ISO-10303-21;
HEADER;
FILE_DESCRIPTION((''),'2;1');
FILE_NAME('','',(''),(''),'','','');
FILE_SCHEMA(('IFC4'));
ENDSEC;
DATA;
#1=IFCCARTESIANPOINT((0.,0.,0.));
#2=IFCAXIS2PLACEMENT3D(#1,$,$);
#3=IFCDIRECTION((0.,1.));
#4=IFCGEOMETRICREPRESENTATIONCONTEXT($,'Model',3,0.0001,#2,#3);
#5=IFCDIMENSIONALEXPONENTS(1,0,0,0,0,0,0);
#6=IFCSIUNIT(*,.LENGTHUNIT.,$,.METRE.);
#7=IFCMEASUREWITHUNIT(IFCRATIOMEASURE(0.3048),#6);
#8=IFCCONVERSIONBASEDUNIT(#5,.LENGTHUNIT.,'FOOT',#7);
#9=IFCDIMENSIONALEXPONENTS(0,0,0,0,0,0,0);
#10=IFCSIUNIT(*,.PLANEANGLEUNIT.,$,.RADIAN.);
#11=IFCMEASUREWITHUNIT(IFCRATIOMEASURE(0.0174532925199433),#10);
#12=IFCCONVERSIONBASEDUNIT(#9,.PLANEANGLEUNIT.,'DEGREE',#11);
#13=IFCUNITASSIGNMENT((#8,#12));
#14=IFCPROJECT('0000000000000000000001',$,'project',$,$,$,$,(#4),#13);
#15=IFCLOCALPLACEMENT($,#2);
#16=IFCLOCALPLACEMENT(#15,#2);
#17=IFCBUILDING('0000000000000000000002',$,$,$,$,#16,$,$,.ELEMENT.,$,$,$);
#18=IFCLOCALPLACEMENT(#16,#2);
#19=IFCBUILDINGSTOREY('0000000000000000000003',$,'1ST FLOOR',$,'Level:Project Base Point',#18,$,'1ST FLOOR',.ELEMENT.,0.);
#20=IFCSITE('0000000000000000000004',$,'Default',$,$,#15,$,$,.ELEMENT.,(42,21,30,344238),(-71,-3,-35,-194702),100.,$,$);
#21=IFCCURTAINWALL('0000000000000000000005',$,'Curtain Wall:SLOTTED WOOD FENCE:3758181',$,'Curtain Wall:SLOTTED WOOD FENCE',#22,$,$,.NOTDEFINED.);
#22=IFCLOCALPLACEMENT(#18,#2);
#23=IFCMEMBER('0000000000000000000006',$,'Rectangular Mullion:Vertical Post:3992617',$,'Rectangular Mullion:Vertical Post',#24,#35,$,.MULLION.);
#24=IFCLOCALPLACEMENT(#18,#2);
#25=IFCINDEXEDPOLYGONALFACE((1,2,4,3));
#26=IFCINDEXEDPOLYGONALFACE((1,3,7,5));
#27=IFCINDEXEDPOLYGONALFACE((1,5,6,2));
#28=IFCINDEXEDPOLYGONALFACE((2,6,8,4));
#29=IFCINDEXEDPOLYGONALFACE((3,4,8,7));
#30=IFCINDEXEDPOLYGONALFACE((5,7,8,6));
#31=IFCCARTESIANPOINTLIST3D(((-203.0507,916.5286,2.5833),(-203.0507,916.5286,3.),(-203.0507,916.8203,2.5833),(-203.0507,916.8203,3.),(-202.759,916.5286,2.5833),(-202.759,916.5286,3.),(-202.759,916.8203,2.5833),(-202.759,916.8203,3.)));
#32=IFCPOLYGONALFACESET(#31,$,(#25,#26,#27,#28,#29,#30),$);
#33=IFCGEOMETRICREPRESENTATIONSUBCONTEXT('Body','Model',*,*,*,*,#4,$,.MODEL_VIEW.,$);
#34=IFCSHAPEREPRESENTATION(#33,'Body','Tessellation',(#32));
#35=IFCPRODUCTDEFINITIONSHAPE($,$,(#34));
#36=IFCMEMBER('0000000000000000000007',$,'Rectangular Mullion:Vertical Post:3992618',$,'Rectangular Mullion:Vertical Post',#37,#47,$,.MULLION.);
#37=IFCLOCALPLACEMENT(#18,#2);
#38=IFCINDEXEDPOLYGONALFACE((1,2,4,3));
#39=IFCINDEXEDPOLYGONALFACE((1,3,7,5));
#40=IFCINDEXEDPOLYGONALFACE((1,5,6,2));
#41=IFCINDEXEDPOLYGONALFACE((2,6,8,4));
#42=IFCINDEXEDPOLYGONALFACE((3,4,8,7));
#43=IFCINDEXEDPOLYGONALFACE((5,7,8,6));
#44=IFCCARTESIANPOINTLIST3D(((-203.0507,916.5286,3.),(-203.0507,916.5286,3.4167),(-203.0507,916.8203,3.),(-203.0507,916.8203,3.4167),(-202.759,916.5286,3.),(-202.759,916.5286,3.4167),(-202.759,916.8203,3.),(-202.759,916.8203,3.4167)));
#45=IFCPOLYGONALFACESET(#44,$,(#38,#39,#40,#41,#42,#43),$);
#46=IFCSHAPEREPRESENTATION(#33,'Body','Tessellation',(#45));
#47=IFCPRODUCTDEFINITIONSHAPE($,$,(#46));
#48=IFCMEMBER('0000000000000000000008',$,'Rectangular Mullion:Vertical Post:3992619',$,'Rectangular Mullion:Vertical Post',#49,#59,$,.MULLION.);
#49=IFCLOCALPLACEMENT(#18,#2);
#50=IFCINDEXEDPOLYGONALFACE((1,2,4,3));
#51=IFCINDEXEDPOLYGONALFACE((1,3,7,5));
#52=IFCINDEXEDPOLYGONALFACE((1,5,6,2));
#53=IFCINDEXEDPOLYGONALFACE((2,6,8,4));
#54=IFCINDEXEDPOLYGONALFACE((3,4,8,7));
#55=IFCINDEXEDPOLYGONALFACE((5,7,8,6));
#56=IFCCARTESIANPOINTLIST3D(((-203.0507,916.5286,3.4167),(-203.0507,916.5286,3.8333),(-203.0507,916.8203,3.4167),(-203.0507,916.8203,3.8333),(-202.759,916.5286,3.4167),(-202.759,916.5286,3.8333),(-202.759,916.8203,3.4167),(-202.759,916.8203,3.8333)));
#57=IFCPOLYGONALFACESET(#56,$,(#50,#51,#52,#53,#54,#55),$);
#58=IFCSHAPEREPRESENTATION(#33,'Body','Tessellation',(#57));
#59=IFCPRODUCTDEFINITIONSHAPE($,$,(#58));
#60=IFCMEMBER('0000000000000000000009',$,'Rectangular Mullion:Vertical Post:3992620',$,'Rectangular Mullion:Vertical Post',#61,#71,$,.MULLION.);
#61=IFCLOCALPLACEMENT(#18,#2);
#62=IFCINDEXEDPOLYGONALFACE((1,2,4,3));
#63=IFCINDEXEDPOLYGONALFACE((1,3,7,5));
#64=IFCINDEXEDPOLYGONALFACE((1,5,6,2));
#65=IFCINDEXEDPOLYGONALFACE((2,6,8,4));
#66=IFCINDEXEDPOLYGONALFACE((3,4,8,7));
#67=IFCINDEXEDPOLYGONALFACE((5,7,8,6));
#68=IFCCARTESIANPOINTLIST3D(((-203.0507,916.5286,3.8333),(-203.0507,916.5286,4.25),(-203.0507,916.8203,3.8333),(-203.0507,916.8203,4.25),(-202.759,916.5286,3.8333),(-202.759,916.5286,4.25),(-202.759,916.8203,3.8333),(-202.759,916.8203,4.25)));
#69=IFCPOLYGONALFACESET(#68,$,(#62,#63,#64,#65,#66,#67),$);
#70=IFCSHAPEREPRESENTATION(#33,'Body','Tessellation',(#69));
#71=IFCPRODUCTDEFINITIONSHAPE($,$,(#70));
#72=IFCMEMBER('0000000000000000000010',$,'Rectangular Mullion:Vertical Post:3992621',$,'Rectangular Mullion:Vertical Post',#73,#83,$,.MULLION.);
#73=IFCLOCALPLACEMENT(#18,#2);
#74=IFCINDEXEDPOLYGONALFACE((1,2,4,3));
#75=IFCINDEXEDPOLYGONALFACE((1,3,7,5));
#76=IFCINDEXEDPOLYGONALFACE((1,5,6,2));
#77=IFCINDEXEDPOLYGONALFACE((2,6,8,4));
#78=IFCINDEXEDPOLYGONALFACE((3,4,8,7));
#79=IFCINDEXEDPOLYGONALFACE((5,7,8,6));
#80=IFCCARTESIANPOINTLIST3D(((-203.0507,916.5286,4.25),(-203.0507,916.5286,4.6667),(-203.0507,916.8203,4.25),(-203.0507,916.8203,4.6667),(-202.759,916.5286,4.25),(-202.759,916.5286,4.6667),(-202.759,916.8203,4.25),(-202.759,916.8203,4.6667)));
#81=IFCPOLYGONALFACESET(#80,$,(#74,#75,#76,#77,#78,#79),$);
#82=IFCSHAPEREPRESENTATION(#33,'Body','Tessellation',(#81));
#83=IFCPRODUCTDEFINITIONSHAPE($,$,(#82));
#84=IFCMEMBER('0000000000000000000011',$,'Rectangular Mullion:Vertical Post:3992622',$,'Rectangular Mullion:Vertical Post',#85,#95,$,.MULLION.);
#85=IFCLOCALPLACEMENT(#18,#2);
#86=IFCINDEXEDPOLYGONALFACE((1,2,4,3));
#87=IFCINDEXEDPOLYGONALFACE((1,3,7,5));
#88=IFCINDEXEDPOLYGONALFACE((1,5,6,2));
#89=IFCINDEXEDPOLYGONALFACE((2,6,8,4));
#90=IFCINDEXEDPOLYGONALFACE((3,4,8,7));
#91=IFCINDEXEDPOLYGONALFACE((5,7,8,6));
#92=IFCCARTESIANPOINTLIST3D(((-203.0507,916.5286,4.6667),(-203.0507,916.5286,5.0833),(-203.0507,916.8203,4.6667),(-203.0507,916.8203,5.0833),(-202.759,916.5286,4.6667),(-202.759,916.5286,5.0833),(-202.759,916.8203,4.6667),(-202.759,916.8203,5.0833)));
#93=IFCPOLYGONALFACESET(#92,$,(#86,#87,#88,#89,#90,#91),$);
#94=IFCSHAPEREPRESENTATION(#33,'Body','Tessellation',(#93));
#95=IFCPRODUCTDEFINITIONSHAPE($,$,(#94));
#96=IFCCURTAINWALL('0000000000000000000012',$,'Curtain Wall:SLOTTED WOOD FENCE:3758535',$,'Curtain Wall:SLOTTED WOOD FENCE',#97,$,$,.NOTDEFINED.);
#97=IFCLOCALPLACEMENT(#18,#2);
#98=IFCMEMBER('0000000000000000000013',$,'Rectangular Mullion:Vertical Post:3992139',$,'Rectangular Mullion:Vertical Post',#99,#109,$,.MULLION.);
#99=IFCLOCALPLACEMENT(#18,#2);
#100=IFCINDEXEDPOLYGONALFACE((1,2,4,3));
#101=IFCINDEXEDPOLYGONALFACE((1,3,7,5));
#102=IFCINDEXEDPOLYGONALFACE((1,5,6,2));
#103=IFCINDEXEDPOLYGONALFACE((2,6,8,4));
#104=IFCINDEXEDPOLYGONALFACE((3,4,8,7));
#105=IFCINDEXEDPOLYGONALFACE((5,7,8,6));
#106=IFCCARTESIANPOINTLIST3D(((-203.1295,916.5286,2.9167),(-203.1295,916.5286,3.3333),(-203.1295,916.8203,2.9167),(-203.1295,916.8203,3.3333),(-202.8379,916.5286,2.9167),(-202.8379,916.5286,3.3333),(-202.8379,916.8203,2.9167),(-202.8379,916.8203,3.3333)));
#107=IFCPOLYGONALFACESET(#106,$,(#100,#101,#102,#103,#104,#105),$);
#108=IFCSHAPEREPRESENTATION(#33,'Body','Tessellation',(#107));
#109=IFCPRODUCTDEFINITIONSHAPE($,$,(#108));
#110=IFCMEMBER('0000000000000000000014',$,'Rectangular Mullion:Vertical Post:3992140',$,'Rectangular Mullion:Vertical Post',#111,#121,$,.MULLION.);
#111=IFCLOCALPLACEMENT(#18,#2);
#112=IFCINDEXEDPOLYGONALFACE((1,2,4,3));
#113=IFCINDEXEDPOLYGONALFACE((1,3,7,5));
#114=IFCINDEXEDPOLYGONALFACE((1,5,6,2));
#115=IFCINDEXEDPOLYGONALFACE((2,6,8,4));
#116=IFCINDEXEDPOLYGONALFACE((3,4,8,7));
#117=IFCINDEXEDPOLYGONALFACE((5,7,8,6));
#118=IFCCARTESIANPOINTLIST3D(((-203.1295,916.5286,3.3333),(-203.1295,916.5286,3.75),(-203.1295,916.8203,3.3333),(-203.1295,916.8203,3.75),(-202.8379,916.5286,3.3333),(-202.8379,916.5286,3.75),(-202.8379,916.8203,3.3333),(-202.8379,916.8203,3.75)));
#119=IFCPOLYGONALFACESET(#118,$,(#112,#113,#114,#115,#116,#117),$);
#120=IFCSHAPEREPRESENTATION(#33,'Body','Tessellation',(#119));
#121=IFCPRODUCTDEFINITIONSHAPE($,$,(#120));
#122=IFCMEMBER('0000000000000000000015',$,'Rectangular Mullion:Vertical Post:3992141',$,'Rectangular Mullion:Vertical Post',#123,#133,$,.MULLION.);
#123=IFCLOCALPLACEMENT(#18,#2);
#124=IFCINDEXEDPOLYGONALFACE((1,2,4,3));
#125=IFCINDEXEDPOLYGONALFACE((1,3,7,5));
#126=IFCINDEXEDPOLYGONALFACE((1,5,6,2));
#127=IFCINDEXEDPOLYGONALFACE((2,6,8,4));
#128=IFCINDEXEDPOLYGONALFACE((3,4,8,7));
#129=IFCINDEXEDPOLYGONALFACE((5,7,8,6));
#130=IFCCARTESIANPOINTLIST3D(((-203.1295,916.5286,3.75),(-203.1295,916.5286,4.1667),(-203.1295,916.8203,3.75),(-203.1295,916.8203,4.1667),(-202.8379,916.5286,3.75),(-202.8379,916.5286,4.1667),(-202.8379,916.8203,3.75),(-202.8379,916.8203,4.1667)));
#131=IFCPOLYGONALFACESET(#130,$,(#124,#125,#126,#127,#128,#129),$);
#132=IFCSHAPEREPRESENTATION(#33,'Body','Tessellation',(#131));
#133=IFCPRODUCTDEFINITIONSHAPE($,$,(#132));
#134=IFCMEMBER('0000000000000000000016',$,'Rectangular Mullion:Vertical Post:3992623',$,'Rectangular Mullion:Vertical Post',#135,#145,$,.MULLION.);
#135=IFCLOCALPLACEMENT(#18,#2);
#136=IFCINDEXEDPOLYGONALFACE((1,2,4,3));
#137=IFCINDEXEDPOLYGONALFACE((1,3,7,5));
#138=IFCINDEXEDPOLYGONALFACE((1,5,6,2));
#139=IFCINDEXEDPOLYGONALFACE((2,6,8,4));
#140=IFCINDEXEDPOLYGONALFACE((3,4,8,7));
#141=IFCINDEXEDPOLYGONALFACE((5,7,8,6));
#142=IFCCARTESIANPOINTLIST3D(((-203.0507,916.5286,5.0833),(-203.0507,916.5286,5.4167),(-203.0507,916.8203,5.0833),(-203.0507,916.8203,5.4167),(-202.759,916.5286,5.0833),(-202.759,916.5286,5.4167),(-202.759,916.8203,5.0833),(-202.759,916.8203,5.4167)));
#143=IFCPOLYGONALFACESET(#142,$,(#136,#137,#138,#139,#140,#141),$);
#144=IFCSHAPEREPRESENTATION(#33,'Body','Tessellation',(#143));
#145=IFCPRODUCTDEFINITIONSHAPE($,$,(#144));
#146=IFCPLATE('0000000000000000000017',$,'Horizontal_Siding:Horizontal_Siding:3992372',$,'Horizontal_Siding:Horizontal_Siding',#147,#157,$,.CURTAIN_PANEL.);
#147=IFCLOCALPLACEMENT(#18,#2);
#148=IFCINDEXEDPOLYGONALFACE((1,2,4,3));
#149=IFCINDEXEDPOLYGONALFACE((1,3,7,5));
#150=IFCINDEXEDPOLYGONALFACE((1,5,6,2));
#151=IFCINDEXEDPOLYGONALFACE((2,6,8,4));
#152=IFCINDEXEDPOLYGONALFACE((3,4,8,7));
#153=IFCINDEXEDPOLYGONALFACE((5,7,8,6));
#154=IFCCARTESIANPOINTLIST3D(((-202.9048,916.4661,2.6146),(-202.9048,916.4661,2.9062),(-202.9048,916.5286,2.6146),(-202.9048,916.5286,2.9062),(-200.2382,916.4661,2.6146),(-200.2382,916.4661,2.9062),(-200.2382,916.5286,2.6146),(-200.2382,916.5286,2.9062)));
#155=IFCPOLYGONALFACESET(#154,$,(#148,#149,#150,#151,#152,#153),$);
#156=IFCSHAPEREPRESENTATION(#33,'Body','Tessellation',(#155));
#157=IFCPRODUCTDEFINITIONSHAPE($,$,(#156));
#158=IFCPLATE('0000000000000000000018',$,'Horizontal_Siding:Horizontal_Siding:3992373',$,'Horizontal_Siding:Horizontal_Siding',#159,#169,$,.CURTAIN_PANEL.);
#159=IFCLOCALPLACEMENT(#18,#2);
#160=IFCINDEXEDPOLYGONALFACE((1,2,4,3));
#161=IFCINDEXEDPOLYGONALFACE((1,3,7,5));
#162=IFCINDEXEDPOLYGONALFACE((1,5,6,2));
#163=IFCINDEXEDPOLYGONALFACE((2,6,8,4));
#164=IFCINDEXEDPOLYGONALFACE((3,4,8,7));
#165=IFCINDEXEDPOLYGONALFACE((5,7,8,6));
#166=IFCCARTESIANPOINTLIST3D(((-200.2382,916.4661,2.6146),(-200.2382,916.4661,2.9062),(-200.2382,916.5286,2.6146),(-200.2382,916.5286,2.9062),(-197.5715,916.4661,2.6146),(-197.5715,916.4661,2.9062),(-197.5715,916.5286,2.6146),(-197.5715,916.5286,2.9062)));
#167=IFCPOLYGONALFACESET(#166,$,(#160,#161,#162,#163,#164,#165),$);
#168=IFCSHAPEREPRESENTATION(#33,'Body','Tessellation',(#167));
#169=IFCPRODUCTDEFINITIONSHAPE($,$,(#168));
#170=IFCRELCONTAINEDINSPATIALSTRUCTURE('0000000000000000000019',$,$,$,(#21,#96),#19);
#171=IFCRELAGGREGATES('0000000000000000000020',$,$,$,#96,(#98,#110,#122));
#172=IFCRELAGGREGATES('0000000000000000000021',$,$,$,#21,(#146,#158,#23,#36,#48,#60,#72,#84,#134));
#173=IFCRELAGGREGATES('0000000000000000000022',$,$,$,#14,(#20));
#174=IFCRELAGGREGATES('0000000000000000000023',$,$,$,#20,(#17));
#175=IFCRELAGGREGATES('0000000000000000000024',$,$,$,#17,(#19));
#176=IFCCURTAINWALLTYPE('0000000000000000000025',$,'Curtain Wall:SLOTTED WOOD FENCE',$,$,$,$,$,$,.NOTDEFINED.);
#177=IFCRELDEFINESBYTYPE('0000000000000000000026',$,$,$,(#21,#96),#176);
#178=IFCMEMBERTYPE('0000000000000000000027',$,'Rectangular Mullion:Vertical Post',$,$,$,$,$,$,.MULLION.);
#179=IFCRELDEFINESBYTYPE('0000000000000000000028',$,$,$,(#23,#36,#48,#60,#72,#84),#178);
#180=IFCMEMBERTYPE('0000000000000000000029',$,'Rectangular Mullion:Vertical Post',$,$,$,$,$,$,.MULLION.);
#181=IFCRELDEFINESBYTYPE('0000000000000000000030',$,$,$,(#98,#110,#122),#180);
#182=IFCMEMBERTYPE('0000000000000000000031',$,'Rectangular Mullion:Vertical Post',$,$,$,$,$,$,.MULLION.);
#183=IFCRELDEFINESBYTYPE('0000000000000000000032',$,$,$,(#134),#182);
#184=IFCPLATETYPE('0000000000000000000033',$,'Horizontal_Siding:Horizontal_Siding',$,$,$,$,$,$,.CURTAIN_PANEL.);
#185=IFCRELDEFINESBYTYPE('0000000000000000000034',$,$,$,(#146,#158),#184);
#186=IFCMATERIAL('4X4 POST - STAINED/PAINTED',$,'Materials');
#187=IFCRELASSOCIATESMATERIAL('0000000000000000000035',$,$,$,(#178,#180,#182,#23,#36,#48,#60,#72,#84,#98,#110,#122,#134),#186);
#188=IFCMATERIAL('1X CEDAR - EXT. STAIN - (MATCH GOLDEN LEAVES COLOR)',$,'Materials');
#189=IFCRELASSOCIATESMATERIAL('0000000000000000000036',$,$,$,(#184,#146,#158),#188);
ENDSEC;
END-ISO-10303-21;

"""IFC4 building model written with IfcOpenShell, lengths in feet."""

from ifc_helpers import new_model, entity, si_unit, converted_unit, direction, frame, frame_2d, origin, origin_2d_with_axis, place, context, subcontext, project, spatial, rectangle, extrude, source, transform, mapped, material, material_profile, profile_set, profile_usage, type_object, type_shapes, element, aggregate, save


model = new_model("IFC4")

# Units and contexts
model_context = context("Model", 3, precision=0.0001, world=origin(), true_north=direction((0.0, 1.0)))
body_context = subcontext(model_context, "Body", "Model", "MODEL_VIEW")
ifc_project = project(units=[converted_unit("LENGTHUNIT", "FOOT", entity("IfcRatioMeasure", 0.3048), si_unit("LENGTHUNIT", "METRE"), dimensions=[1, 0, 0, 0, 0, 0, 0]), converted_unit("PLANEANGLEUNIT", "DEGREE", entity("IfcRatioMeasure", 0.0174532925199433), si_unit("PLANEANGLEUNIT", "RADIAN"), dimensions=[0, 0, 0, 0, 0, 0, 0])], contexts=[model_context])

# Site, building, storey
site_placement = place(None, origin())
site = spatial("IfcSite", under=ifc_project, at=site_placement, Name="Default", CompositionType="ELEMENT", RefLatitude=(42, 21, 30, 344238), RefLongitude=(-71, -3, -35, -194702), RefElevation=100.0)
building_placement = place(site_placement, origin())
building = spatial("IfcBuilding", under=site, at=building_placement, CompositionType="ELEMENT")
storey_placement = place(building_placement, origin())
storey = spatial("IfcBuildingStorey", under=building, at=storey_placement, Name="1ST FLOOR", ObjectType="Level:Project Base Point", LongName="1ST FLOOR", CompositionType="ELEMENT", Elevation=0.0)

# Curtain walls, members
curtain_wall_type = type_object("IfcCurtainWallType", Name="Curtain Wall:SLOTTED WOOD FENCE", PredefinedType="NOTDEFINED")
curtain_wall_1_placement = place(storey_placement, origin())
curtain_wall_1 = element("IfcCurtainWall", 1, at=curtain_wall_1_placement, inside=storey, type_object=curtain_wall_type, Name="Curtain Wall:SLOTTED WOOD FENCE:3758181", ObjectType="Curtain Wall:SLOTTED WOOD FENCE", PredefinedType="NOTDEFINED")
ifc_material_1 = material(Name="4X4 POST - STAINED/PAINTED", Category="Materials")
ifc_material_profile = material_profile(ifc_material_1, rectangle(XDim=0.2917, YDim=0.2917, at=origin_2d_with_axis()), Name="Vertical Post")
ifc_profile_set = profile_set([ifc_material_profile], Name="Vertical Post")
ifc_profile_usage_1 = profile_usage(ifc_profile_set)
member_type_1 = type_object("IfcMemberType", Name="Rectangular Mullion:Vertical Post", PredefinedType="MULLION", material=ifc_profile_set)
shared_shape_1 = source(origin(), body_context, "Body", "SweptSolid", [
    extrude(rectangle(XDim=0.2917, YDim=0.2917, at=origin_2d_with_axis()), frame((0.0, -0.2083, -0.4167), z_axis=(0.0, 0.0, 1.0), x_axis=(0.0, -1.0, 0.0)), (0.0, 0.0, 1.0), 0.4167),
])
type_shapes(member_type_1, [shared_shape_1])
member_1_placement = place(storey_placement, frame((-202.9048, 916.4661, 2.5833), z_axis=(0.0, 0.0, -1.0), x_axis=(1.0, 0.0, 0.0)))
member_1 = element("IfcMember", 2, at=member_1_placement, type_object=member_type_1, material=ifc_profile_usage_1, Name="Rectangular Mullion:Vertical Post:3992617", ObjectType="Rectangular Mullion:Vertical Post", PredefinedType="MULLION", context=body_context, shape_type="MappedRepresentation", body=[
    mapped(shared_shape_1, transform((0.0, 0.0, 0.0), scale=1.0)),
])
ifc_profile_usage_2 = profile_usage(ifc_profile_set)
member_2_placement = place(storey_placement, frame((-202.9048, 916.4661, 3.0), z_axis=(0.0, 0.0, -1.0), x_axis=(1.0, 0.0, 0.0)))
member_2 = element("IfcMember", 3, at=member_2_placement, type_object=member_type_1, material=ifc_profile_usage_2, Name="Rectangular Mullion:Vertical Post:3992618", ObjectType="Rectangular Mullion:Vertical Post", PredefinedType="MULLION", context=body_context, shape_type="MappedRepresentation", body=[
    mapped(shared_shape_1, transform((0.0, 0.0, 0.0), scale=1.0)),
])
ifc_profile_usage_3 = profile_usage(ifc_profile_set)
member_3_placement = place(storey_placement, frame((-202.9048, 916.4661, 3.4167), z_axis=(0.0, 0.0, -1.0), x_axis=(1.0, 0.0, 0.0)))
member_3 = element("IfcMember", 4, at=member_3_placement, type_object=member_type_1, material=ifc_profile_usage_3, Name="Rectangular Mullion:Vertical Post:3992619", ObjectType="Rectangular Mullion:Vertical Post", PredefinedType="MULLION", context=body_context, shape_type="MappedRepresentation", body=[
    mapped(shared_shape_1, transform((0.0, 0.0, 0.0), scale=1.0)),
])
ifc_profile_usage_4 = profile_usage(ifc_profile_set)
member_4_placement = place(storey_placement, frame((-202.9048, 916.4661, 3.8333), z_axis=(0.0, 0.0, -1.0), x_axis=(1.0, 0.0, 0.0)))
member_4 = element("IfcMember", 5, at=member_4_placement, type_object=member_type_1, material=ifc_profile_usage_4, Name="Rectangular Mullion:Vertical Post:3992620", ObjectType="Rectangular Mullion:Vertical Post", PredefinedType="MULLION", context=body_context, shape_type="MappedRepresentation", body=[
    mapped(shared_shape_1, transform((0.0, 0.0, 0.0), scale=1.0)),
])
ifc_profile_usage_5 = profile_usage(ifc_profile_set)
member_5_placement = place(storey_placement, frame((-202.9048, 916.4661, 4.25), z_axis=(0.0, 0.0, -1.0), x_axis=(1.0, 0.0, 0.0)))
member_5 = element("IfcMember", 6, at=member_5_placement, type_object=member_type_1, material=ifc_profile_usage_5, Name="Rectangular Mullion:Vertical Post:3992621", ObjectType="Rectangular Mullion:Vertical Post", PredefinedType="MULLION", context=body_context, shape_type="MappedRepresentation", body=[
    mapped(shared_shape_1, transform((0.0, 0.0, 0.0), scale=1.0)),
])
ifc_profile_usage_6 = profile_usage(ifc_profile_set)
member_6_placement = place(storey_placement, frame((-202.9048, 916.4661, 4.6667), z_axis=(0.0, 0.0, -1.0), x_axis=(1.0, 0.0, 0.0)))
member_6 = element("IfcMember", 7, at=member_6_placement, type_object=member_type_1, material=ifc_profile_usage_6, Name="Rectangular Mullion:Vertical Post:3992622", ObjectType="Rectangular Mullion:Vertical Post", PredefinedType="MULLION", context=body_context, shape_type="MappedRepresentation", body=[
    mapped(shared_shape_1, transform((0.0, 0.0, 0.0), scale=1.0)),
])
curtain_wall_2_placement = place(storey_placement, origin())
curtain_wall_2 = element("IfcCurtainWall", 8, at=curtain_wall_2_placement, inside=storey, type_object=curtain_wall_type, Name="Curtain Wall:SLOTTED WOOD FENCE:3758535", ObjectType="Curtain Wall:SLOTTED WOOD FENCE", PredefinedType="NOTDEFINED")
ifc_profile_usage_7 = profile_usage(ifc_profile_set)
member_type_2 = type_object("IfcMemberType", Name="Rectangular Mullion:Vertical Post", PredefinedType="MULLION", material=ifc_profile_set)
shared_shape_2 = source(origin(), body_context, "Body", "SweptSolid", [
    extrude(rectangle(XDim=0.2917, YDim=0.2917, at=frame_2d((0.0, 0.0), x_axis=(1.0, 0.0))), frame((-0.1458, 0.2083, -0.4167), z_axis=(0.0, 0.0, 1.0), x_axis=(0.0, -1.0, 0.0)), (0.0, 0.0, 1.0), 0.4167),
])
type_shapes(member_type_2, [shared_shape_2])
member_7_placement = place(storey_placement, frame((-202.7754, 916.5286, 2.9167), z_axis=(0.0, 0.0, -1.0), x_axis=(0.0, -1.0, 0.0)))
member_7 = element("IfcMember", 9, at=member_7_placement, type_object=member_type_2, material=ifc_profile_usage_7, Name="Rectangular Mullion:Vertical Post:3992139", ObjectType="Rectangular Mullion:Vertical Post", PredefinedType="MULLION", context=body_context, shape_type="MappedRepresentation", body=[
    mapped(shared_shape_2, transform((0.0, 0.0, 0.0), scale=1.0)),
])
ifc_profile_usage_8 = profile_usage(ifc_profile_set)
member_8_placement = place(storey_placement, frame((-202.7754, 916.5286, 3.3333), z_axis=(0.0, 0.0, -1.0), x_axis=(0.0, -1.0, 0.0)))
member_8 = element("IfcMember", 10, at=member_8_placement, type_object=member_type_2, material=ifc_profile_usage_8, Name="Rectangular Mullion:Vertical Post:3992140", ObjectType="Rectangular Mullion:Vertical Post", PredefinedType="MULLION", context=body_context, shape_type="MappedRepresentation", body=[
    mapped(shared_shape_2, transform((0.0, 0.0, 0.0), scale=1.0)),
])
ifc_profile_usage_9 = profile_usage(ifc_profile_set)
member_9_placement = place(storey_placement, frame((-202.7754, 916.5286, 3.75), z_axis=(0.0, 0.0, -1.0), x_axis=(0.0, -1.0, 0.0)))
member_9 = element("IfcMember", 11, at=member_9_placement, type_object=member_type_2, material=ifc_profile_usage_9, Name="Rectangular Mullion:Vertical Post:3992141", ObjectType="Rectangular Mullion:Vertical Post", PredefinedType="MULLION", context=body_context, shape_type="MappedRepresentation", body=[
    mapped(shared_shape_2, transform((0.0, 0.0, 0.0), scale=1.0)),
])
aggregate(curtain_wall_2, [member_7, member_8, member_9])

# Member
ifc_profile_usage_10 = profile_usage(ifc_profile_set)
member_type_3 = type_object("IfcMemberType", Name="Rectangular Mullion:Vertical Post", PredefinedType="MULLION", material=ifc_profile_set)
shared_shape_3 = source(origin(), body_context, "Body", "SweptSolid", [
    extrude(rectangle(XDim=0.2917, YDim=0.2917, at=origin_2d_with_axis()), frame((0.0, -0.2083, -0.3333), z_axis=(0.0, 0.0, 1.0), x_axis=(0.0, -1.0, 0.0)), (0.0, 0.0, 1.0), 0.3333),
])
type_shapes(member_type_3, [shared_shape_3])
member_10_placement = place(storey_placement, frame((-202.9048, 916.4661, 5.0833), z_axis=(0.0, 0.0, -1.0), x_axis=(1.0, 0.0, 0.0)))
member_10 = element("IfcMember", 12, at=member_10_placement, type_object=member_type_3, material=ifc_profile_usage_10, Name="Rectangular Mullion:Vertical Post:3992623", ObjectType="Rectangular Mullion:Vertical Post", PredefinedType="MULLION", context=body_context, shape_type="MappedRepresentation", body=[
    mapped(shared_shape_3, transform((0.0, 0.0, 0.0), scale=1.0)),
])

# Plates
ifc_material_2 = material(Name="1X CEDAR - EXT. STAIN - (MATCH GOLDEN LEAVES COLOR)", Category="Materials")
plate_type_1 = type_object("IfcPlateType", Name="Horizontal_Siding:Horizontal_Siding", PredefinedType="CURTAIN_PANEL", material=ifc_material_2)
shared_shape_4 = source(origin(), body_context, "Body", "SweptSolid", [
    extrude(rectangle(XDim=2.6667, YDim=0.0625, at=origin_2d_with_axis()), frame((1.3333, 0.0312, 0.0), z_axis=(0.0, 0.0, 1.0), x_axis=(-1.0, 0.0, 0.0)), (0.0, 0.0, 1.0), 0.2917),
])
type_shapes(plate_type_1, [shared_shape_4])
plate_1_placement = place(curtain_wall_1_placement, frame((-202.9048, 916.4661, 2.6146)))
plate_1 = element("IfcPlate", 13, at=plate_1_placement, type_object=plate_type_1, material=ifc_material_2, Name="Horizontal_Siding:Horizontal_Siding:3992372", ObjectType="Horizontal_Siding:Horizontal_Siding", PredefinedType="CURTAIN_PANEL", context=body_context, shape_type="MappedRepresentation", body=[
    mapped(shared_shape_4, transform((0.0, 0.0, 0.0), scale=1.0)),
])
plate_2_placement = place(curtain_wall_1_placement, frame((-200.2382, 916.4661, 2.6146)))
plate_2 = element("IfcPlate", 14, at=plate_2_placement, type_object=plate_type_1, material=ifc_material_2, Name="Horizontal_Siding:Horizontal_Siding:3992373", ObjectType="Horizontal_Siding:Horizontal_Siding", PredefinedType="CURTAIN_PANEL", context=body_context, shape_type="MappedRepresentation", body=[
    mapped(shared_shape_4, transform((0.0, 0.0, 0.0), scale=1.0)),
])
aggregate(curtain_wall_1, [plate_1, plate_2, member_1, member_2, member_3, member_4, member_5, member_6, member_10])

save(model, "model.ifc")
